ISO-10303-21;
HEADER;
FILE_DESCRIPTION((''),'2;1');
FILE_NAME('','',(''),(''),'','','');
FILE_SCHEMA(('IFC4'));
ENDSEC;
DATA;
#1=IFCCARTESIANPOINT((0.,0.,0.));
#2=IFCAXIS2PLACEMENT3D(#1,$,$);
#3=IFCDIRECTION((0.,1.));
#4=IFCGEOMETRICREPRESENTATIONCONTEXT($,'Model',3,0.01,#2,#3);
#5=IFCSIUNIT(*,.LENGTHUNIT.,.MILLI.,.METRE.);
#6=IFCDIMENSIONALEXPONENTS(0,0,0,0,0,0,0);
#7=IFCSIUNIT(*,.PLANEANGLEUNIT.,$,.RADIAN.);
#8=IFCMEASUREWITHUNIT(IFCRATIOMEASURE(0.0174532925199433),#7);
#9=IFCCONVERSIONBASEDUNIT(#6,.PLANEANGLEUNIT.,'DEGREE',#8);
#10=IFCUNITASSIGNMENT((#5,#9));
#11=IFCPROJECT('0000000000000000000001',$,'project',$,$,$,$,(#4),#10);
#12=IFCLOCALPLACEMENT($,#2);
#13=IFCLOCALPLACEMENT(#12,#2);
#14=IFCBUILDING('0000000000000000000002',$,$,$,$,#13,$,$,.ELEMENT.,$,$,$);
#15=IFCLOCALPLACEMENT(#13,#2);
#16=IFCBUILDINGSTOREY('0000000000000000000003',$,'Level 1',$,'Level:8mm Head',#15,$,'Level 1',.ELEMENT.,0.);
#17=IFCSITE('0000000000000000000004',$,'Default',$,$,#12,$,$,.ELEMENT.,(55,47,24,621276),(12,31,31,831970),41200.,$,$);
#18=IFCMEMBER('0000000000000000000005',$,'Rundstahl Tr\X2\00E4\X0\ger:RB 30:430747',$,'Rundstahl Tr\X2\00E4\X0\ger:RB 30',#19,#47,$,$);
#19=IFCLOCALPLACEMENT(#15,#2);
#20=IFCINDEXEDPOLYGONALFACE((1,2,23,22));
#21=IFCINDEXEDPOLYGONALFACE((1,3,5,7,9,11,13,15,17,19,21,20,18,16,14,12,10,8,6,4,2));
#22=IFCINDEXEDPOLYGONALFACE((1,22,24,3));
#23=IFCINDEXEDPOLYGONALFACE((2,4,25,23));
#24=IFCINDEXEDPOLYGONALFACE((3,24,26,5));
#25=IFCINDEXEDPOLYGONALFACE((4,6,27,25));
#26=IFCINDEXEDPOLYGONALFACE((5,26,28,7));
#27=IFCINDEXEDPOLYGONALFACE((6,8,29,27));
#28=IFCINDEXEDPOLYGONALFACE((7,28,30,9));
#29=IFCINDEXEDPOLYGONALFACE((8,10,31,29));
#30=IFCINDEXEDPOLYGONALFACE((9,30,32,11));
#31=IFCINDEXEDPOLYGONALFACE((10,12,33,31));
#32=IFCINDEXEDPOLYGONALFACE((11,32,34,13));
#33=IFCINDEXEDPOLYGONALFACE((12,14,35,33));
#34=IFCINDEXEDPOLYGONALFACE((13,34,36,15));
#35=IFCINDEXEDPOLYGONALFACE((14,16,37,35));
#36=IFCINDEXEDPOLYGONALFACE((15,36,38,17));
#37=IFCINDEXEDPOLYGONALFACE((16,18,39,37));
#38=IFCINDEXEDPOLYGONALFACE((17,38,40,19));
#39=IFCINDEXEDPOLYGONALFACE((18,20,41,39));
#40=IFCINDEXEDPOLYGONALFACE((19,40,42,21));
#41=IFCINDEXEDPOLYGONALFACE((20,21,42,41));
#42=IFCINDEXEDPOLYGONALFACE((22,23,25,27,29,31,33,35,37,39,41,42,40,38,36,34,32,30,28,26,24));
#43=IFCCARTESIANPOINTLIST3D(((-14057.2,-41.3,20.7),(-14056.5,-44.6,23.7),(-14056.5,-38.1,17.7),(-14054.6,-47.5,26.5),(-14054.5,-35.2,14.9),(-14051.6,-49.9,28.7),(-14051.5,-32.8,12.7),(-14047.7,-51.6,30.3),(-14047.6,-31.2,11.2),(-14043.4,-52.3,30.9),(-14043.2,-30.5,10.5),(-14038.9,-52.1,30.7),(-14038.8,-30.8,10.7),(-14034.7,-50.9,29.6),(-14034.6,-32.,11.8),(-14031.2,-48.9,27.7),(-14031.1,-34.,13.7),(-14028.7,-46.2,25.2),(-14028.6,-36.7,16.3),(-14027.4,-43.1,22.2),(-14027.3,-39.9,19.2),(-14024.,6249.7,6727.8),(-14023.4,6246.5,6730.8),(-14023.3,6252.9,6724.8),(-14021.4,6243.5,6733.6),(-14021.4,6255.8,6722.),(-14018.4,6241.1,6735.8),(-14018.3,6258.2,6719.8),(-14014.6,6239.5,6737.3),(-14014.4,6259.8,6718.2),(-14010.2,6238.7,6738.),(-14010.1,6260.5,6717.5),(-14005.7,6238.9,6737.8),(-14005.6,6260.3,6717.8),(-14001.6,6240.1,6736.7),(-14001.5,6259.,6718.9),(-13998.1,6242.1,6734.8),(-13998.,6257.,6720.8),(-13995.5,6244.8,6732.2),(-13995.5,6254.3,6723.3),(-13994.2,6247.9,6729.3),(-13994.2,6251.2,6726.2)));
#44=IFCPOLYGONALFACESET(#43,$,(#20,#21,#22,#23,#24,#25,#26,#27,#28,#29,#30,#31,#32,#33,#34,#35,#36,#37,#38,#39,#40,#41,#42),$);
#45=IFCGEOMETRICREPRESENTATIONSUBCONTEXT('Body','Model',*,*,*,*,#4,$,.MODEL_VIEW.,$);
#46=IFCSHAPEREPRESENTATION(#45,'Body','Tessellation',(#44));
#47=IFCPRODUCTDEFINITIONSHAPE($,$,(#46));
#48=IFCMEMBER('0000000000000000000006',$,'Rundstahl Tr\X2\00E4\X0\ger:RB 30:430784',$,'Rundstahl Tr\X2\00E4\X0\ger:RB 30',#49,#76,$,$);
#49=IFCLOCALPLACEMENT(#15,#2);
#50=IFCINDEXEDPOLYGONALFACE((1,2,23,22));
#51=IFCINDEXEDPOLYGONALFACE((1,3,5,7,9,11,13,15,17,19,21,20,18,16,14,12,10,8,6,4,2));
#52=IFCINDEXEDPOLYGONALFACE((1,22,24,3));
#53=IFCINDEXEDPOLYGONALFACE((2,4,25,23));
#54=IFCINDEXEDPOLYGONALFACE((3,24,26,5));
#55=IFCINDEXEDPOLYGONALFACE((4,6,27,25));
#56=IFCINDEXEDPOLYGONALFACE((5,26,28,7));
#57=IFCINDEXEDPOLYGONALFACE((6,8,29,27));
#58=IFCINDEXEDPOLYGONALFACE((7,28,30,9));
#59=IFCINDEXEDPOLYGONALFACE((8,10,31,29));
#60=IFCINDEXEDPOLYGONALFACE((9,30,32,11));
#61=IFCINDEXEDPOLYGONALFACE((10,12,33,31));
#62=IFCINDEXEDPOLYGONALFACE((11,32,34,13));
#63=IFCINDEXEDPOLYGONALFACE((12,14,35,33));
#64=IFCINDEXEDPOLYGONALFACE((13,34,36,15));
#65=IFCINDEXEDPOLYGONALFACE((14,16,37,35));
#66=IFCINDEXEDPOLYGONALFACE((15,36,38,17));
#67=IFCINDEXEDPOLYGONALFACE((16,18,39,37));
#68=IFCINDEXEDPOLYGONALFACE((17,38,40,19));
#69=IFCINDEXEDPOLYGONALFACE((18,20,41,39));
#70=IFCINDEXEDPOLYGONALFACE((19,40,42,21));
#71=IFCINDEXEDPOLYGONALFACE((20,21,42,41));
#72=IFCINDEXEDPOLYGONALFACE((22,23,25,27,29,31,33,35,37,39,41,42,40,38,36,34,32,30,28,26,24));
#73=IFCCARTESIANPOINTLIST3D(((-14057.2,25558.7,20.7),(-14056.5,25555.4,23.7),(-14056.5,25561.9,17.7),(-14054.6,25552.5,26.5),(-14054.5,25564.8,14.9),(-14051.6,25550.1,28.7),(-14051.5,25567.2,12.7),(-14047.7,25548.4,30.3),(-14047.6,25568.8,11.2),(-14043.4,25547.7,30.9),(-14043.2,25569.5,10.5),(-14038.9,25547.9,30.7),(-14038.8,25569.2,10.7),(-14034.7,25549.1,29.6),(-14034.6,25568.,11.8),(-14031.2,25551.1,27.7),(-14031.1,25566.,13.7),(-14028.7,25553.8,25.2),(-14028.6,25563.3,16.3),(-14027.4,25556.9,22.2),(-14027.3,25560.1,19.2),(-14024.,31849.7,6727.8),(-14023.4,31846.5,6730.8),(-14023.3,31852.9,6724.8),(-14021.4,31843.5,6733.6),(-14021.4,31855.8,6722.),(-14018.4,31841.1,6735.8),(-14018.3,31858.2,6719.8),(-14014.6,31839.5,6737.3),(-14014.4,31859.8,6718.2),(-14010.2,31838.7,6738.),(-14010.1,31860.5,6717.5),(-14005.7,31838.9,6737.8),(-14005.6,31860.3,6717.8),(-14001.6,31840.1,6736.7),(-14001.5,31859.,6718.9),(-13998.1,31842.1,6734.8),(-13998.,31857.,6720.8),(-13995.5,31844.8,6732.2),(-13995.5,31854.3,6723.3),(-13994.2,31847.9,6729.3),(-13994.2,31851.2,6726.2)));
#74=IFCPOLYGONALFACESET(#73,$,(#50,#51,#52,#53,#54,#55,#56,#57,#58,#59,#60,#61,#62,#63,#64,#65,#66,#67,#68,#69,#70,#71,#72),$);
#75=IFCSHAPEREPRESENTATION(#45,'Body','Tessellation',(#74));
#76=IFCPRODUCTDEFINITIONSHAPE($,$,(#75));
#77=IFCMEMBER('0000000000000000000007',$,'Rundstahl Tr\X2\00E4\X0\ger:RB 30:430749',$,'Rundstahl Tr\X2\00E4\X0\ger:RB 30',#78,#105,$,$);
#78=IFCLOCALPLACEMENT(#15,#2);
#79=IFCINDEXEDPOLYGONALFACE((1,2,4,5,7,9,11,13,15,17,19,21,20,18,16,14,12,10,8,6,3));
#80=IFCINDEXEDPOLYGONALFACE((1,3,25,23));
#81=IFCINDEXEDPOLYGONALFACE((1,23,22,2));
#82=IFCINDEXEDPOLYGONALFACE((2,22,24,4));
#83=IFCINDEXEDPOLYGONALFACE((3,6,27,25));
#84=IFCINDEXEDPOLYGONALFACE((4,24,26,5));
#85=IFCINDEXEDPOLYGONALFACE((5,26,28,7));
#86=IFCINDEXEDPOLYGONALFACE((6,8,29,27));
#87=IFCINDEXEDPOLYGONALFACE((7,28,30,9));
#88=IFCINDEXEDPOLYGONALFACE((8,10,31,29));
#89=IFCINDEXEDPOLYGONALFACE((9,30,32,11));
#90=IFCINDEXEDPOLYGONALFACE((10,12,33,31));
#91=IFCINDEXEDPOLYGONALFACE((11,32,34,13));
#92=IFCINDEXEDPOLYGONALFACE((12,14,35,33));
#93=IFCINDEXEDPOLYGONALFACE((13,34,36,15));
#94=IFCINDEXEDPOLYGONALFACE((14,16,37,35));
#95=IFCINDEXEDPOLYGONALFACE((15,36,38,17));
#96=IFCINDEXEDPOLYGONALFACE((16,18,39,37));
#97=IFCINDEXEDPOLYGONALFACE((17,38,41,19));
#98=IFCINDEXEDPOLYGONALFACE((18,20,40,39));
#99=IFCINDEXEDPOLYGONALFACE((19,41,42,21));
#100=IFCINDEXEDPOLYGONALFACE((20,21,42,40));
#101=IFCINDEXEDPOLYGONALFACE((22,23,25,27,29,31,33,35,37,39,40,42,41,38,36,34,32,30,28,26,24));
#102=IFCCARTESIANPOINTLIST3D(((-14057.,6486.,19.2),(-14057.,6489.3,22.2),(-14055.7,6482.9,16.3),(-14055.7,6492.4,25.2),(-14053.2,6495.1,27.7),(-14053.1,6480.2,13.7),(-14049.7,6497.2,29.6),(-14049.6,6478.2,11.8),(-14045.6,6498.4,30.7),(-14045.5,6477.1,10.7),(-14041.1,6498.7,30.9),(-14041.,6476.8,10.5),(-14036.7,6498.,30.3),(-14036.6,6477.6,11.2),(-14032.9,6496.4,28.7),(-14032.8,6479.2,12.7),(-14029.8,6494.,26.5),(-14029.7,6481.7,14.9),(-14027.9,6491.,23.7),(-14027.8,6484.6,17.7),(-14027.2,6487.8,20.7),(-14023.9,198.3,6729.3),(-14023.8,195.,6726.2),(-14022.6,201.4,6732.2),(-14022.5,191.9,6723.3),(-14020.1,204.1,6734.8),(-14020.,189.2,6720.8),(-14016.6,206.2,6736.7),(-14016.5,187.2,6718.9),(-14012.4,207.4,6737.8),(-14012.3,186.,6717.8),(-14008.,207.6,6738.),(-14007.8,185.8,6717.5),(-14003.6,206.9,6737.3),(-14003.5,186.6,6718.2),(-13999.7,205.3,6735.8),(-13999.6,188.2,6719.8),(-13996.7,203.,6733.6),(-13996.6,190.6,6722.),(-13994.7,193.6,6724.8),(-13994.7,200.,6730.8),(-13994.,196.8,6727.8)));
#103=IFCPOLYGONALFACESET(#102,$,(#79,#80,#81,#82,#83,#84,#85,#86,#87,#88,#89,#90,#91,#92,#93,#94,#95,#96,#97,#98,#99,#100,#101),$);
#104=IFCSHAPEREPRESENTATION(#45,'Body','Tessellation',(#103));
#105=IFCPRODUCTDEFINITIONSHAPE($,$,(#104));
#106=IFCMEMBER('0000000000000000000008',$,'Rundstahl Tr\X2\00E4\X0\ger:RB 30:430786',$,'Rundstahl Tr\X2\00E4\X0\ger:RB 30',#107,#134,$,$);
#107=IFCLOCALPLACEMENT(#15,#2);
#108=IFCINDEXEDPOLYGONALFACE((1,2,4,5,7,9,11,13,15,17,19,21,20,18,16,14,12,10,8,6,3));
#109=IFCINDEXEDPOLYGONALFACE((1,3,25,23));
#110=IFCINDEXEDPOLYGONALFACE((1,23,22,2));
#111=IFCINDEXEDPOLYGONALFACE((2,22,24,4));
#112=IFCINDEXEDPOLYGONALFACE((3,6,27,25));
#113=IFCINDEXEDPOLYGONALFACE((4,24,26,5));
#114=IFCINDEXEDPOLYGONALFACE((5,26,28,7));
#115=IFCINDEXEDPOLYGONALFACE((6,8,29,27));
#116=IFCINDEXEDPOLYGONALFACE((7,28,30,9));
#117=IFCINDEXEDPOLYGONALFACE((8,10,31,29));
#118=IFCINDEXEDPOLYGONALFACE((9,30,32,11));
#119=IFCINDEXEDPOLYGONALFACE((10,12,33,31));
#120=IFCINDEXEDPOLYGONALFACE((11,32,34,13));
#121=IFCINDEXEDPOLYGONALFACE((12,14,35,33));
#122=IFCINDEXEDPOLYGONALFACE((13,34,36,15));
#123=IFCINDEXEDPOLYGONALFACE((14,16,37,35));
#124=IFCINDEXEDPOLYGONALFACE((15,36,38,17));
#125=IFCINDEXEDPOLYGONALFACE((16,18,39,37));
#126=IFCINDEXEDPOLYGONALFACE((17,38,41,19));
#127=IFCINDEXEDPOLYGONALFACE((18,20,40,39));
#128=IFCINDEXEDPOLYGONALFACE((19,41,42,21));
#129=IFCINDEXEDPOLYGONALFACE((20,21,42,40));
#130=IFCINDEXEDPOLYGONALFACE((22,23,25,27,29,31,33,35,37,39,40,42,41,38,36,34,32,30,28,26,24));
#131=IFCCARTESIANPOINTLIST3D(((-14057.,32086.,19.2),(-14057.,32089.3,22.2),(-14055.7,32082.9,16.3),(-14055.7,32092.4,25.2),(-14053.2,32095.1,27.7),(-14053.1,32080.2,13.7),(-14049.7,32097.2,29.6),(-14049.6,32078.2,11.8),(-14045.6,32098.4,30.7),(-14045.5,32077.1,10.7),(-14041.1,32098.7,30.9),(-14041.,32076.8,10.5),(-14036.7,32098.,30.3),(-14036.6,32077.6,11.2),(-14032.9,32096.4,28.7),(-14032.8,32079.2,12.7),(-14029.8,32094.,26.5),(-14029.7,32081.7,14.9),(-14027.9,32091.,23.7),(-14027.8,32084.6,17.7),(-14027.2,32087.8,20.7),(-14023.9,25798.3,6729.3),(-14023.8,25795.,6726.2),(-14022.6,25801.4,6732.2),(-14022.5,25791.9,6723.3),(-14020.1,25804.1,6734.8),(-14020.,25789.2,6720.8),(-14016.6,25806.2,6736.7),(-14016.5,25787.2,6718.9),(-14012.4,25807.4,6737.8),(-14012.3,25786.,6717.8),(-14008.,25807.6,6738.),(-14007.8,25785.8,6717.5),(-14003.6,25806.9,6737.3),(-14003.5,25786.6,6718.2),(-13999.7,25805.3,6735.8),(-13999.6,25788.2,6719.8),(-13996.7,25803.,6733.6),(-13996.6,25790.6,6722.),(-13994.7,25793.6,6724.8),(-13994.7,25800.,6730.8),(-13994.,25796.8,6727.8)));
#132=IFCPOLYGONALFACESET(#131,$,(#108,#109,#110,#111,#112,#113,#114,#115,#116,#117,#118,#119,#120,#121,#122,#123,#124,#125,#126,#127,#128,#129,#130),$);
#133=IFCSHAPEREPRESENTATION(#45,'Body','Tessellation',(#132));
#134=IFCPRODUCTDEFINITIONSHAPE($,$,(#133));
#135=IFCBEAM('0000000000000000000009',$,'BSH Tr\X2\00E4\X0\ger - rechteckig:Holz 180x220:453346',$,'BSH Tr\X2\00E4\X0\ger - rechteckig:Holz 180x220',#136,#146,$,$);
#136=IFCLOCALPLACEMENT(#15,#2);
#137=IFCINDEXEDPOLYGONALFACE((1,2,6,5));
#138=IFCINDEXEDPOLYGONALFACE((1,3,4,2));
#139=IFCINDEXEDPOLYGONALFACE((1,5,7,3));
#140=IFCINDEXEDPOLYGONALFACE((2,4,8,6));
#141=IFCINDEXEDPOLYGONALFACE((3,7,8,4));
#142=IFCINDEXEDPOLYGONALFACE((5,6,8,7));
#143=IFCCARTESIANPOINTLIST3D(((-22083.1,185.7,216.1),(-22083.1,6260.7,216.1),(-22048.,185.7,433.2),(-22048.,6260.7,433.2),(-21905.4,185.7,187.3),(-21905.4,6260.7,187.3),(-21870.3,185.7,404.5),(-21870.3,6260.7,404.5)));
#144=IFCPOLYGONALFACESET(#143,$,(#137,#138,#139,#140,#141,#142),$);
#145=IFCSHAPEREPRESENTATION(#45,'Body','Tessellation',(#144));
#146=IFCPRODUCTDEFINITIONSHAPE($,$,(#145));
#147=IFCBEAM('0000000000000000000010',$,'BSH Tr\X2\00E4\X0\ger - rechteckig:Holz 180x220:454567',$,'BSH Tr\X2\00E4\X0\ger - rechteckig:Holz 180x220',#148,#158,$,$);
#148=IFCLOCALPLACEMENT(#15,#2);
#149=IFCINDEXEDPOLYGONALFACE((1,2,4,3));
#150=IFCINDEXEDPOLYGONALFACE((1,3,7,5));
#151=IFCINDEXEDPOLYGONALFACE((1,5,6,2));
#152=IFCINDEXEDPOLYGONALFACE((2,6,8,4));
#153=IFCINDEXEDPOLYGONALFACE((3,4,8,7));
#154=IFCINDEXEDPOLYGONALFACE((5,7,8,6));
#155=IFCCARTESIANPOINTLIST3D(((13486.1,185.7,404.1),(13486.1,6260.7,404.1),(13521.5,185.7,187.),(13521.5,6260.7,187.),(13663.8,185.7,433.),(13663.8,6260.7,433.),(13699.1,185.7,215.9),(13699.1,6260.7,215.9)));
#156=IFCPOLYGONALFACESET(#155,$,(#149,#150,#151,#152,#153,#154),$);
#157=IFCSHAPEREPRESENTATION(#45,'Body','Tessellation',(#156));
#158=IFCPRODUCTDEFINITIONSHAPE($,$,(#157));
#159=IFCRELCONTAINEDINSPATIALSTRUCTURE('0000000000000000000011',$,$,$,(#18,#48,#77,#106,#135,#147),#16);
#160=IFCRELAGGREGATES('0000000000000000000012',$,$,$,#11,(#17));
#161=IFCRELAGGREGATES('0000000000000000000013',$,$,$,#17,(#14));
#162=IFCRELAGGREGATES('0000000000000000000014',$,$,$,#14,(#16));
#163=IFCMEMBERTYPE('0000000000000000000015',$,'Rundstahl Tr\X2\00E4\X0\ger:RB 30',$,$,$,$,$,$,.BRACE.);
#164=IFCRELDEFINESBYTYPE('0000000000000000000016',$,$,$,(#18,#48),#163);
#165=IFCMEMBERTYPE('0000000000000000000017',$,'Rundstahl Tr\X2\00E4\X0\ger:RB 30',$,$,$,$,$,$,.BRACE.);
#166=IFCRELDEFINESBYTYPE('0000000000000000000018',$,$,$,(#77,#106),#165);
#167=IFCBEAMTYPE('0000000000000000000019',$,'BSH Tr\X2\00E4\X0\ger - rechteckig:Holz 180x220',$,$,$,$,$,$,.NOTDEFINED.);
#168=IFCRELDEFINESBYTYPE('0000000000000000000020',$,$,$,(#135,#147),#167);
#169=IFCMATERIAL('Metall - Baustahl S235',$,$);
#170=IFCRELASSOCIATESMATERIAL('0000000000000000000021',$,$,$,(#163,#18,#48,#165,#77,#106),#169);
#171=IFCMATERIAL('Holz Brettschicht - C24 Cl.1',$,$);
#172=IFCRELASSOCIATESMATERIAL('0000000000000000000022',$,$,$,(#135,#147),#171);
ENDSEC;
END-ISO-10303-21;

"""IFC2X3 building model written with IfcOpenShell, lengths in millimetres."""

from ifc_helpers import new_model, entity, si_unit, converted_unit, direction, frame, frame_2d, origin, place, context, subcontext, project, spatial, rectangle, circle, extrude, source, transform, mapped, material, type_object, type_shapes, element, save


model = new_model("IFC2X3")

# Units and contexts
model_context = context("Model", 3, precision=0.01, world=origin(), true_north=direction((0.0, 1.0)))
body_context = subcontext(model_context, "Body", "Model", "MODEL_VIEW")
ifc_project = project(units=[si_unit("LENGTHUNIT", "METRE", prefix="MILLI"), converted_unit("PLANEANGLEUNIT", "DEGREE", entity("IfcRatioMeasure", 0.0174532925199433), si_unit("PLANEANGLEUNIT", "RADIAN"), dimensions=[0, 0, 0, 0, 0, 0, 0])], contexts=[model_context])

# Site, building, storey
site_placement = place(None, origin())
site = spatial("IfcSite", under=ifc_project, at=site_placement, Name="Default", CompositionType="ELEMENT", RefLatitude=(55, 47, 24, 621276), RefLongitude=(12, 31, 31, 831970), RefElevation=41200.0)
building_placement = place(site_placement, origin())
building = spatial("IfcBuilding", under=site, at=building_placement, CompositionType="ELEMENT")
storey_placement = place(building_placement, origin())
storey = spatial("IfcBuildingStorey", under=building, at=storey_placement, Name="Level 1", ObjectType="Level:8mm Head", LongName="Level 1", CompositionType="ELEMENT", Elevation=0.0)

# Shared definitions
ifc_material_1 = material(Name="Holz Brettschicht - C24 Cl.1")

# Members
ifc_material_2 = material(Name="Metall - Baustahl S235")
member_type_1 = type_object("IfcMemberType", Name="Rundstahl Träger:RB 30", PredefinedType="BRACE", material=ifc_material_2)
shared_shape_1 = source(origin(), body_context, "Body", "SweptSolid", [
    extrude(circle(Radius=15.0, at=frame_2d((0.0, 0.0), x_axis=(1.0, 0.0))), frame((-4423.9, 0.0, 0.0), z_axis=(1.0, 0.0, 0.0), x_axis=(0.0, -1.0, 0.0)), (0.0, 0.0, 1.0), 9195.8),
])
type_shapes(member_type_1, [shared_shape_1])
for number, where, z_axis, x_axis, name in (
    (1, (-14025.0, 3223.2, 3501.2), (-0.003844, -0.729352, 0.684128), (-0.003605, -0.684118, -0.729362), "Rundstahl Träger:RB 30:430747"),
    (2, (-14025.0, 28823.2, 3501.2), (-0.003844, -0.729352, 0.684128), (-0.003605, -0.684118, -0.729362), "Rundstahl Träger:RB 30:430784"),
):
    element("IfcMember", number, at=place(storey_placement, frame(where, z_axis=z_axis, x_axis=x_axis)), inside=storey, type_object=member_type_1, material=ifc_material_2, Name=name, ObjectType="Rundstahl Träger:RB 30", context=body_context, shape_type="MappedRepresentation", body=[
        mapped(shared_shape_1, transform((0.0, 0.0, 0.0), scale=1.0)),
    ])
member_type_2 = type_object("IfcMemberType", Name="Rundstahl Träger:RB 30", PredefinedType="BRACE", material=ifc_material_2)
shared_shape_2 = source(origin(), body_context, "Body", "SweptSolid", [
    extrude(circle(Radius=15.0, at=frame_2d((0.0, 0.0), x_axis=(1.0, 0.0))), frame((-4423.9, 0.0, 0.0), z_axis=(1.0, 0.0, 0.0), x_axis=(0.0, -1.0, 0.0)), (0.0, 0.0, 1.0), 9195.8),
])
type_shapes(member_type_2, [shared_shape_2])
for number, where, z_axis, x_axis, name in (
    (3, (-14025.0, 3223.2, 3501.2), (-0.003844, 0.729352, 0.684128), (-0.003605, 0.684118, -0.729362), "Rundstahl Träger:RB 30:430749"),
    (4, (-14025.0, 28823.2, 3501.2), (-0.003844, 0.729352, 0.684128), (-0.003605, 0.684118, -0.729362), "Rundstahl Träger:RB 30:430786"),
):
    element("IfcMember", number, at=place(storey_placement, frame(where, z_axis=z_axis, x_axis=x_axis)), inside=storey, type_object=member_type_2, material=ifc_material_2, Name=name, ObjectType="Rundstahl Träger:RB 30", context=body_context, shape_type="MappedRepresentation", body=[
        mapped(shared_shape_2, transform((0.0, 0.0, 0.0), scale=1.0)),
    ])

# Beams
beam_type_1 = type_object("IfcBeamType", Name="BSH Träger - rechteckig:Holz 180x220", PredefinedType="NOTDEFINED")
beam_1_placement = place(storey_placement, frame((-22048.0, 5823.2, 433.2), z_axis=(0.0, 0.0, 1.0), x_axis=(0.0, -1.0, 0.0)))
element("IfcBeam", 5, at=beam_1_placement, inside=storey, type_object=beam_type_1, material=ifc_material_1, Name="BSH Träger - rechteckig:Holz 180x220:453346", ObjectType="BSH Träger - rechteckig:Holz 180x220", context=body_context, shape_type="SweptSolid", body=[
    extrude(rectangle(XDim=220.0, YDim=180.0, at=frame_2d((0.0, 0.0), x_axis=(1.0, 0.0))), frame((-437.5, 71.3, -123.0), z_axis=(1.0, 0.0, 0.0), x_axis=(0.0, 0.159701, 0.987165)), (0.0, 0.0, 1.0), 6075.0),
])
beam_2_placement = place(storey_placement, frame((13681.5, 923.2, 324.5), z_axis=(0.0, 0.0, 1.0), x_axis=(0.0, 1.0, 0.0)))
element("IfcBeam", 6, at=beam_2_placement, inside=storey, type_object=beam_type_1, material=ifc_material_1, Name="BSH Träger - rechteckig:Holz 180x220:454567", ObjectType="BSH Träger - rechteckig:Holz 180x220", context=body_context, shape_type="SweptSolid", body=[
    extrude(rectangle(XDim=220.0, YDim=180.0, at=frame_2d((0.0, 0.0), x_axis=(1.0, 0.0))), frame((-737.5, 88.8, -14.5), z_axis=(1.0, 0.0, 0.0), x_axis=(0.0, 0.160724, 0.986999)), (0.0, 0.0, 1.0), 6075.0),
])

save(model, "model.ifc")
